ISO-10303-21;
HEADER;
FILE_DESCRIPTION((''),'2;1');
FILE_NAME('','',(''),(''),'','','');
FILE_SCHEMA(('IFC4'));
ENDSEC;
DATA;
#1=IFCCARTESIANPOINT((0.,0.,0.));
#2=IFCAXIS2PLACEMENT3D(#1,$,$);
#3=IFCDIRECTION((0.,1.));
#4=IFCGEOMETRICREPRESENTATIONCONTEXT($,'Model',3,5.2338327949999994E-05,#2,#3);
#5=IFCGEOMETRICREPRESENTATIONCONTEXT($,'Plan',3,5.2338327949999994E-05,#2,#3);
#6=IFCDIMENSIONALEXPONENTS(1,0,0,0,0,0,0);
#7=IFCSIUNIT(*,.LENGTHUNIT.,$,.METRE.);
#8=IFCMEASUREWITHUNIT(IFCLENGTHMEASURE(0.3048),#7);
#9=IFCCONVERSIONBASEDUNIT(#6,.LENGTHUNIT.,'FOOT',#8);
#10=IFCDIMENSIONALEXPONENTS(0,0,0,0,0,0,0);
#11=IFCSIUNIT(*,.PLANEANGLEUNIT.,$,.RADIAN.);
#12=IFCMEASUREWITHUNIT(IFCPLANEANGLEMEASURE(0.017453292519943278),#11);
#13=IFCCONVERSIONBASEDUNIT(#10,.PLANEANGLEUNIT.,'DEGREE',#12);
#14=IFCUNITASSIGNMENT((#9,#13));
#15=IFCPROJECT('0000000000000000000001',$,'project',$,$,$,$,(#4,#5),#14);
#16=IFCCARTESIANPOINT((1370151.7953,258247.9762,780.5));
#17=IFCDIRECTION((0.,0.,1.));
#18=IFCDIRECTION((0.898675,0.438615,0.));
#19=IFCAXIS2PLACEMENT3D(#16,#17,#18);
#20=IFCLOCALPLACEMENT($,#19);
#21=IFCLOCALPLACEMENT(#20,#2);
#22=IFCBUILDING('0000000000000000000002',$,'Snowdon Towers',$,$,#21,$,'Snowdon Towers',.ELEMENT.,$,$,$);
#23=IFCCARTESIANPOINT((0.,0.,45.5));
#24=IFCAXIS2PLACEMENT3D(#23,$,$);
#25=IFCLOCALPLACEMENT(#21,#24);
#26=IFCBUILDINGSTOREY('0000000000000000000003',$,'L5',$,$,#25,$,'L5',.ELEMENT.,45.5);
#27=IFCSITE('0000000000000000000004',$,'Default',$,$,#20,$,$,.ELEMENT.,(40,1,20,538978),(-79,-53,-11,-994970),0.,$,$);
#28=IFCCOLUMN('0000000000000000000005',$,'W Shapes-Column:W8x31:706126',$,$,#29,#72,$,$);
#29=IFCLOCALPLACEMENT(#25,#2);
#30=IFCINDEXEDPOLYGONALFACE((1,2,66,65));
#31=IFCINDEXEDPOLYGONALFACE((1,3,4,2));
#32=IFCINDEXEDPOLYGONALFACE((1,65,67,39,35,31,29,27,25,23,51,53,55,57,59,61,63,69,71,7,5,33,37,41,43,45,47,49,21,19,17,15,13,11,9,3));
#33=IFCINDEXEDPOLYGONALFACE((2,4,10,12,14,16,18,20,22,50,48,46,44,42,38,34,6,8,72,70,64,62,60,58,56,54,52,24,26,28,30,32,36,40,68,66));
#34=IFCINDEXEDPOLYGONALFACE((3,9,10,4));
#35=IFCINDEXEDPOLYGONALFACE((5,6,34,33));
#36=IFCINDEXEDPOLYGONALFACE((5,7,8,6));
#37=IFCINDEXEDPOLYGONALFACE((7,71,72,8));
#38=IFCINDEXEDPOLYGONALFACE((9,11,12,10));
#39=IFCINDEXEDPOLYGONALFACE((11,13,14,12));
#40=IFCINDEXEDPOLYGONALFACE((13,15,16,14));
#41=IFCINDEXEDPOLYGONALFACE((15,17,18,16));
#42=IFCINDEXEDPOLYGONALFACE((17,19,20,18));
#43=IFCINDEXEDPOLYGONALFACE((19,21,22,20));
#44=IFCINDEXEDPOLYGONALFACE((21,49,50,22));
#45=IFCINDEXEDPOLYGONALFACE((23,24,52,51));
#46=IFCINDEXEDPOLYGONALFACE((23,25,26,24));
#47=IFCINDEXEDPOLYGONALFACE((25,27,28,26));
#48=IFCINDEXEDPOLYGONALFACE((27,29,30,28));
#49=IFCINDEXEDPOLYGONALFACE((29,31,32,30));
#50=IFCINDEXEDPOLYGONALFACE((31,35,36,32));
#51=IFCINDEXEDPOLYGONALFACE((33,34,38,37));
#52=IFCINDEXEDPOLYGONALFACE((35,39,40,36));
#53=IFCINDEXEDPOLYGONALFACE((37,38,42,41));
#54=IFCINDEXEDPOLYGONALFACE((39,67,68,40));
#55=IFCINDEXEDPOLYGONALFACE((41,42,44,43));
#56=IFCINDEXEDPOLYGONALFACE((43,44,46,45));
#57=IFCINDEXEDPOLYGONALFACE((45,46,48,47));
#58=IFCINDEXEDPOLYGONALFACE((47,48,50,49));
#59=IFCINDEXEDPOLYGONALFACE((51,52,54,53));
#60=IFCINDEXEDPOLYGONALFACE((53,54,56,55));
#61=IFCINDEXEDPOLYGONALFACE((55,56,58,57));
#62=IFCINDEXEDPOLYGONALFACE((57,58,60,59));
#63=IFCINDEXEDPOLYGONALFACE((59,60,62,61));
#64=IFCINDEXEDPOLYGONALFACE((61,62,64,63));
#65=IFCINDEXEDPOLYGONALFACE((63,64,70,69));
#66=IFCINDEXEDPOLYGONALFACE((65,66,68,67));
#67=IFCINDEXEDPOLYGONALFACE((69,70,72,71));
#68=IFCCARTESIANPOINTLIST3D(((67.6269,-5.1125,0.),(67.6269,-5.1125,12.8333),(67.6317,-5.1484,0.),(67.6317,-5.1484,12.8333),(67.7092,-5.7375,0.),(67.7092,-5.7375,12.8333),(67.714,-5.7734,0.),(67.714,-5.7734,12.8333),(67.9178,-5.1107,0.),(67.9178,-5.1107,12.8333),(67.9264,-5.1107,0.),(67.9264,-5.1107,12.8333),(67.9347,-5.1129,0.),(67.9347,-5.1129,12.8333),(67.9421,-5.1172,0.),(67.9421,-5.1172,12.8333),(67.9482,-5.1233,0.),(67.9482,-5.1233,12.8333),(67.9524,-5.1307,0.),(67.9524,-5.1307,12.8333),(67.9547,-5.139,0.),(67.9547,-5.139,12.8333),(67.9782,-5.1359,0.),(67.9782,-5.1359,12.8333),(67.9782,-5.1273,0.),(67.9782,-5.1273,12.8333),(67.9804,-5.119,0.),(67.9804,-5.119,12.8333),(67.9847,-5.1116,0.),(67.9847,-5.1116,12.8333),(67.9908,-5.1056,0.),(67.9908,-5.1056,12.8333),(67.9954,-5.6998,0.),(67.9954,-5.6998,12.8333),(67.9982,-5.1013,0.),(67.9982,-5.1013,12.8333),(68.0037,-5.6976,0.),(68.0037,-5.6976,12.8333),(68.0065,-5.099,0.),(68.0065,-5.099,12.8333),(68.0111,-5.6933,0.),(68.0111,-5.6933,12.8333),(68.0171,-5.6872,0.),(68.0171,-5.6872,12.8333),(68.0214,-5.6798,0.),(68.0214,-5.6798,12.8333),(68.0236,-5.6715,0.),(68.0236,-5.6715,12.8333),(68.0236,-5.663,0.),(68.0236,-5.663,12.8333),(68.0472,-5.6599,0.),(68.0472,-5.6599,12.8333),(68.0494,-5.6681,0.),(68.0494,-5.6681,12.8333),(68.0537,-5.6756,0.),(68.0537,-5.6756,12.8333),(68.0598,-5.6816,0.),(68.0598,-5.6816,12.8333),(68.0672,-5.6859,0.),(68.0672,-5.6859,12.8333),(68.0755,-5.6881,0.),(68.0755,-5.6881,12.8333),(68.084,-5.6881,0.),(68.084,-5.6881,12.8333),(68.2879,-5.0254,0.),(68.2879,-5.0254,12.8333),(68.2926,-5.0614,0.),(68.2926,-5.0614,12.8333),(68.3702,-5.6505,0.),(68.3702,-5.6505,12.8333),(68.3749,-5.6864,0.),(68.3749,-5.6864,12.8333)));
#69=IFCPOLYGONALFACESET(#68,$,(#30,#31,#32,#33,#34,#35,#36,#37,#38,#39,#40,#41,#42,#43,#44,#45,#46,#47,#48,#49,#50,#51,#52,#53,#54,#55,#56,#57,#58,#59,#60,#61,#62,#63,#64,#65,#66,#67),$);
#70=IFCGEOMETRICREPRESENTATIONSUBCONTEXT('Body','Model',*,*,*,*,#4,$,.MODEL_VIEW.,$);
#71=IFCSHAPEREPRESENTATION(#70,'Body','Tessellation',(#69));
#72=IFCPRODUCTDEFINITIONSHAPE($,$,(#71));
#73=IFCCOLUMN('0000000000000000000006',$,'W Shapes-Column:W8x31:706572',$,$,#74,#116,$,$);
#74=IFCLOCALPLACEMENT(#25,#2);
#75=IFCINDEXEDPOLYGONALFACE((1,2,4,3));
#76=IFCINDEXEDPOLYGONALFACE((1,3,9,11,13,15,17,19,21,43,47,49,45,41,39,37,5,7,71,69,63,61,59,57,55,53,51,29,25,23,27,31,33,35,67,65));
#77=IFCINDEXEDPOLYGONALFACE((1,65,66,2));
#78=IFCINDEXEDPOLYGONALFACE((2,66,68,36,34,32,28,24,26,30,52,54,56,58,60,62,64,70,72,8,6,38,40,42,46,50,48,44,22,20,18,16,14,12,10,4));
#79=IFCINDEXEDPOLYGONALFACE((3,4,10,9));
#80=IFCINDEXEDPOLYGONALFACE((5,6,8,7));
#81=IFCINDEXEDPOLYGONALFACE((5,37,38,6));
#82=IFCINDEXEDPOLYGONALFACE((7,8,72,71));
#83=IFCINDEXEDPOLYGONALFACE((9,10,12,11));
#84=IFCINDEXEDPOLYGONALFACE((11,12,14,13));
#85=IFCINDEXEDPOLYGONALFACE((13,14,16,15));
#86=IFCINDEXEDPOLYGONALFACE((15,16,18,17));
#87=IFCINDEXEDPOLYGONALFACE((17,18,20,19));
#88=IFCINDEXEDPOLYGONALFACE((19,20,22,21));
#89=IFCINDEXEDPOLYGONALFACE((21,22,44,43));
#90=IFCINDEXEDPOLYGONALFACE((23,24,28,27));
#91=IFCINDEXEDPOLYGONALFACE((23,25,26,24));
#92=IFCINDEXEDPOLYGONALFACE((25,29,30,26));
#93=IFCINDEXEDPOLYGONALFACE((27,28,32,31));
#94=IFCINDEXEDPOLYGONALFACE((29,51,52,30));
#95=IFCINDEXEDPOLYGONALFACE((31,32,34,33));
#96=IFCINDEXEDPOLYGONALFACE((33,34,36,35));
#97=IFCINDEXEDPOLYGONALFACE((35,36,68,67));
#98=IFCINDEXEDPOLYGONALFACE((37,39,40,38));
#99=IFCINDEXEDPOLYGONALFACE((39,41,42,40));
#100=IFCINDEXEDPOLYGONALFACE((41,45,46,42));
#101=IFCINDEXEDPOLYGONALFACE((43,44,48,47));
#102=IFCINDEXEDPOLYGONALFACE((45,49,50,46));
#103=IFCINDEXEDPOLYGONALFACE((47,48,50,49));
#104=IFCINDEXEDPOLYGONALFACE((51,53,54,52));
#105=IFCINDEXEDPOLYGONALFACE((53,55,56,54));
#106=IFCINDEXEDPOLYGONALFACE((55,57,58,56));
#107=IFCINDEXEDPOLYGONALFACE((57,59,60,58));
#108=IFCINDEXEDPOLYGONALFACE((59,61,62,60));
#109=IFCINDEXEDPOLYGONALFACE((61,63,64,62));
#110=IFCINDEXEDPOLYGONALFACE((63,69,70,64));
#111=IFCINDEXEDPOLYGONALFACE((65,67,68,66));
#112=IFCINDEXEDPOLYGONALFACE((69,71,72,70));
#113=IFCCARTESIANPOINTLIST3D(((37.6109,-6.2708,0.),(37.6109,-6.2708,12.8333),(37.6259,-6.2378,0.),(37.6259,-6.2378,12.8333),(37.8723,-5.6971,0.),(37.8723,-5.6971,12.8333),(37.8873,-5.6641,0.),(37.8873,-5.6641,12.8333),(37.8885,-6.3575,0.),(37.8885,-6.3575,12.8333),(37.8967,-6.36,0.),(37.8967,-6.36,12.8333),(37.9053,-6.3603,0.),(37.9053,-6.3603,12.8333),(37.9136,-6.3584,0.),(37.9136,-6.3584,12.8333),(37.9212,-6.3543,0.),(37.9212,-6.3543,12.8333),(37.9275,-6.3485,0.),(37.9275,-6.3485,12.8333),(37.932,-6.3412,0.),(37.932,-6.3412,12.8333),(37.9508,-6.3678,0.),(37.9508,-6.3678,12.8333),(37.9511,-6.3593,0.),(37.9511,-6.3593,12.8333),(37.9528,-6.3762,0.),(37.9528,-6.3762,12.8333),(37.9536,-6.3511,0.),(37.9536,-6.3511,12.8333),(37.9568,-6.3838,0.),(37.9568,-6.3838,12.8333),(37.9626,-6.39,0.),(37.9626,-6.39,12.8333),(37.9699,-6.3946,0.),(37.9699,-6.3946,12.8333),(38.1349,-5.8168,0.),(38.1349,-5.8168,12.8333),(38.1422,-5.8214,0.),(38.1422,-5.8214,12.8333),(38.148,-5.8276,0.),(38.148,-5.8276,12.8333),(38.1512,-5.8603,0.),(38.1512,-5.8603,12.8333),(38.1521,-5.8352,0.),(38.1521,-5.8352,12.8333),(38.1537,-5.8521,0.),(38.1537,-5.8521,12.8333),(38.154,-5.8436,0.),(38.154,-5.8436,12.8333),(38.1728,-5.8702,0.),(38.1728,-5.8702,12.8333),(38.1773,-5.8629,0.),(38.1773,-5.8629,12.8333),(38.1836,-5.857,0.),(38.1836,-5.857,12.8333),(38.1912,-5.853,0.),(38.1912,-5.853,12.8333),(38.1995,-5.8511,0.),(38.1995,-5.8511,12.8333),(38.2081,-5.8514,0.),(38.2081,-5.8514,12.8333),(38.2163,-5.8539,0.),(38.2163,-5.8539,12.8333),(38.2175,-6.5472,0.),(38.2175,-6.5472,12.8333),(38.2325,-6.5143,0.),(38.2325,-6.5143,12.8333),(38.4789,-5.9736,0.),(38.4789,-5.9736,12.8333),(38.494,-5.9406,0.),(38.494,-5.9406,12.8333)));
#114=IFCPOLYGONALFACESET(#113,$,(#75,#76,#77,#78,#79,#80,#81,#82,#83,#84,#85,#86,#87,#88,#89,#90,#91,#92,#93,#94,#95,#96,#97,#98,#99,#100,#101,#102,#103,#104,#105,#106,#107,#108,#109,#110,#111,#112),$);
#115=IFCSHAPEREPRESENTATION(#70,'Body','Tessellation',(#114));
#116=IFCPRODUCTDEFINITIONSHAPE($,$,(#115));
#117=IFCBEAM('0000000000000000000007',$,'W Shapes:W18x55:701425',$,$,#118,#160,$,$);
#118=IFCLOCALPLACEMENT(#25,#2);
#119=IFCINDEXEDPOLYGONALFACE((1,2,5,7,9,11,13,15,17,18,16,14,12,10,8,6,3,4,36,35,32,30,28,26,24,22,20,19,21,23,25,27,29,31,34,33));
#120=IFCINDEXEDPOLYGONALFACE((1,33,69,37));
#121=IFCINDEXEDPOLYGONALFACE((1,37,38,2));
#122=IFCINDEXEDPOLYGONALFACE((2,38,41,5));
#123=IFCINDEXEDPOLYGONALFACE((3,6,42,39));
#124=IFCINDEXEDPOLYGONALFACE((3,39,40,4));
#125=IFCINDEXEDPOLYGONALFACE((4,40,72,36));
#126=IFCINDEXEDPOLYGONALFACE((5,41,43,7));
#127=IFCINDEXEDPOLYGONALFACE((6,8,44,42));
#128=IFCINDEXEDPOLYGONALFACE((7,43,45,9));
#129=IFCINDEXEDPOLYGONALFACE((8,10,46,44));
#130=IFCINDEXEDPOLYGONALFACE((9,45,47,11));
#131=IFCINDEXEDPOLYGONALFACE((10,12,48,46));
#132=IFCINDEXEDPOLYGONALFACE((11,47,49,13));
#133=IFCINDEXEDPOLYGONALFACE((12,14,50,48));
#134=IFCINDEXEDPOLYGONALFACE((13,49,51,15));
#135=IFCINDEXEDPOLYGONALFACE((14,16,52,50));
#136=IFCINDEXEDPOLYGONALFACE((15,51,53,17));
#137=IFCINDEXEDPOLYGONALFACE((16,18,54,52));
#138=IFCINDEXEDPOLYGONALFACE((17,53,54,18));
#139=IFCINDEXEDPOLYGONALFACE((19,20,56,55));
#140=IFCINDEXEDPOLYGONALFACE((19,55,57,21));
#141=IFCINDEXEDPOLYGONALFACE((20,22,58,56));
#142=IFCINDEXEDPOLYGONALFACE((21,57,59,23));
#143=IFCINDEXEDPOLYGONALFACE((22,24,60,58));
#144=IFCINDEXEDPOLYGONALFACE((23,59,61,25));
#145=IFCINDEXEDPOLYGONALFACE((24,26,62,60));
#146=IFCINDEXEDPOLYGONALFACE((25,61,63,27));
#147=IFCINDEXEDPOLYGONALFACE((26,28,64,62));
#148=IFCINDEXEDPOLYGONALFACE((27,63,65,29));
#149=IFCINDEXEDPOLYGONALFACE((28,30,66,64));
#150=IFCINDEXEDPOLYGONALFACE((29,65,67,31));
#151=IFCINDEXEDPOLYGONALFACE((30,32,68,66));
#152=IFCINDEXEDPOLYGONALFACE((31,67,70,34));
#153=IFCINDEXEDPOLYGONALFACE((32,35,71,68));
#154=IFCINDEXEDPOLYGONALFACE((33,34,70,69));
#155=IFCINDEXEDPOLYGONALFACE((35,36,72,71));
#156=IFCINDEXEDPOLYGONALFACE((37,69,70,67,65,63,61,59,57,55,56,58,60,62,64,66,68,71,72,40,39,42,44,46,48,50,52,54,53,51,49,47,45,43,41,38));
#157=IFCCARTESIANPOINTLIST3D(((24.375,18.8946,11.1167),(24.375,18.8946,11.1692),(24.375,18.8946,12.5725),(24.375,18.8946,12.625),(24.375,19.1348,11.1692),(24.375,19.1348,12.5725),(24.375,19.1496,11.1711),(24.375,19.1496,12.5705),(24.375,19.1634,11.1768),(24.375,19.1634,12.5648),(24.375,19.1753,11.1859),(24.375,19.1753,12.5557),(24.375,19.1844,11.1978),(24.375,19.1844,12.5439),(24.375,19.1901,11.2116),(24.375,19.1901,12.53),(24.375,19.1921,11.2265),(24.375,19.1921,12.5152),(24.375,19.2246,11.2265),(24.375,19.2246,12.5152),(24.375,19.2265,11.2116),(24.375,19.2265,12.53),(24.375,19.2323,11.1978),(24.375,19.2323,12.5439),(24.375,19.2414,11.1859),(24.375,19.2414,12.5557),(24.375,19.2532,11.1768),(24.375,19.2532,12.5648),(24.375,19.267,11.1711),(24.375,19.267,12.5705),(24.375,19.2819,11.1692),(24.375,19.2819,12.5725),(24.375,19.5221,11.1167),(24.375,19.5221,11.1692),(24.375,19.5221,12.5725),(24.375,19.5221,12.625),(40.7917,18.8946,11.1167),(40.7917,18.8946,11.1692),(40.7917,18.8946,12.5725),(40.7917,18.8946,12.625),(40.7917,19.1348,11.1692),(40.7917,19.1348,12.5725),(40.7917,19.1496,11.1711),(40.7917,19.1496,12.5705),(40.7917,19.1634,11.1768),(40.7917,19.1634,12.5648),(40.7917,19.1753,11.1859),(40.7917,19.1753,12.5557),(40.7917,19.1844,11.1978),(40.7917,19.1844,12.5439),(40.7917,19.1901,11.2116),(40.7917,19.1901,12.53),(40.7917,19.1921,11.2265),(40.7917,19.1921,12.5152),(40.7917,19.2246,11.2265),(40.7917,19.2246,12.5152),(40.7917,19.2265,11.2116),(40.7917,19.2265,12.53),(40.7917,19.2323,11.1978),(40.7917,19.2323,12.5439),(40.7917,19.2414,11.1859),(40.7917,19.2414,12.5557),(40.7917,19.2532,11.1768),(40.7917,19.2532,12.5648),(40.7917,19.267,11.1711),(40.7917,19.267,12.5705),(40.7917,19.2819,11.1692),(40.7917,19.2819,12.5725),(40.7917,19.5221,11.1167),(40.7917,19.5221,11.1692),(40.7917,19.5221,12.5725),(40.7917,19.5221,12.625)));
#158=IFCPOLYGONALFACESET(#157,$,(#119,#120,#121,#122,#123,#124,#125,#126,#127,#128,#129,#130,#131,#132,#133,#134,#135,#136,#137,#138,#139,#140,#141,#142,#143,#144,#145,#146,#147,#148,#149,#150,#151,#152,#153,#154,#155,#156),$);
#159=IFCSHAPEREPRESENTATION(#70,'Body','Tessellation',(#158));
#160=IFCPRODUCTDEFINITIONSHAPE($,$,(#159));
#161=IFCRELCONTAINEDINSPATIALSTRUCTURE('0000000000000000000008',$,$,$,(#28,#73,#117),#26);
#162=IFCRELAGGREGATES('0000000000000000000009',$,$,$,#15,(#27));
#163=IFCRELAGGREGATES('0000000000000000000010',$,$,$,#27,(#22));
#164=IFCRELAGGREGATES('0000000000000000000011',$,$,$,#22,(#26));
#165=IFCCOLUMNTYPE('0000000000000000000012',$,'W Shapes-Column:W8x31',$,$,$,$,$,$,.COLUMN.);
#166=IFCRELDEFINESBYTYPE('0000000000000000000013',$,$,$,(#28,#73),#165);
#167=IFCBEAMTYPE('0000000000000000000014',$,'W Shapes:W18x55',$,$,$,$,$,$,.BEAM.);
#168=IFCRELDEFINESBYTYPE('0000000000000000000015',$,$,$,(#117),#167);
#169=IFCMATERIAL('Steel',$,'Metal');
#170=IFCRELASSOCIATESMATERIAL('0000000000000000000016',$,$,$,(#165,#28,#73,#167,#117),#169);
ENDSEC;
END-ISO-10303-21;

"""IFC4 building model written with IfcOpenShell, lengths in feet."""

from ifc_helpers import new_model, entity, si_unit, converted_unit, direction, frame, origin, place, context, subcontext, project, spatial, line, arc, indexed_curve, outline, extrude, source, transform, mapped, material, type_object, type_shapes, element, save


model = new_model("IFC4")

# Units and contexts
model_context = context("Model", 3, precision=5.2338327949999994e-05, world=origin(), true_north=direction((0.0, 1.0)))
plan_context = context("Plan", 3, precision=5.2338327949999994e-05, world=origin(), true_north=direction((0.0, 1.0)))
body_context = subcontext(model_context, "Body", "Model", "MODEL_VIEW")
ifc_project = project(units=[converted_unit("LENGTHUNIT", "FOOT", entity("IfcLengthMeasure", 0.3048), si_unit("LENGTHUNIT", "METRE"), dimensions=[1, 0, 0, 0, 0, 0, 0]), converted_unit("PLANEANGLEUNIT", "DEGREE", entity("IfcPlaneAngleMeasure", 0.017453292519943278), si_unit("PLANEANGLEUNIT", "RADIAN"), dimensions=[0, 0, 0, 0, 0, 0, 0])], contexts=[model_context, plan_context])

# Site, building, storey
site_placement = place(None, frame((1370151.7953, 258247.9762, 780.5), z_axis=(0.0, 0.0, 1.0), x_axis=(0.898675, 0.438615, 0.0)))
site = spatial("IfcSite", under=ifc_project, at=site_placement, Name="Default", CompositionType="ELEMENT", RefLatitude=(40, 1, 20, 538978), RefLongitude=(-79, -53, -11, -994970), RefElevation=0.0)
building_placement = place(site_placement, origin())
building = spatial("IfcBuilding", under=site, at=building_placement, Name="Snowdon Towers", LongName="Snowdon Towers", CompositionType="ELEMENT")
storey_placement = place(building_placement, frame((0.0, 0.0, 45.5)))
storey = spatial("IfcBuildingStorey", under=building, at=storey_placement, Name="L5", LongName="L5", CompositionType="ELEMENT", Elevation=45.5)

# Columns
ifc_material = material(Name="Steel", Category="Metal")
column_type = type_object("IfcColumnType", Name="W Shapes-Column:W8x31", PredefinedType="COLUMN", material=ifc_material)
shared_shape_1 = source(origin(), body_context, "Body", "SweptSolid", [
    extrude(outline(indexed_curve([(-0.3333, -0.3333), (0.3333, -0.3333), (0.3333, -0.2971), (0.0447, -0.2971), (0.0215, -0.2875), (0.0119, -0.2642), (0.0119, 0.2642), (0.0215, 0.2875), (0.0447, 0.2971), (0.3333, 0.2971), (0.3333, 0.3333), (-0.3333, 0.3333), (-0.3333, 0.2971), (-0.0447, 0.2971), (-0.0215, 0.2875), (-0.0119, 0.2643), (-0.0119, -0.2642), (-0.0215, -0.2875), (-0.0447, -0.2971), (-0.3333, -0.2971)], segments=[line(1, 2, 3, 4), arc(4, 5, 6), line(6, 7), arc(7, 8, 9), line(9, 10, 11, 12, 13, 14), arc(14, 15, 16), line(16, 17), arc(17, 18, 19), line(19, 20, 1)], self_intersect=False)), frame((0.0, 0.0, 45.5), z_axis=(0.0, 0.0, 1.0), x_axis=(-1.0, 0.0, 0.0)), (0.0, 0.0, 1.0), 12.8333),
])
type_shapes(column_type, [shared_shape_1])
for number, where, z_axis, x_axis, name in (
    (1, (68.0009, -5.3994, -45.5), (0.0, 0.0, 1.0), (0.991445, 0.130526, 0.0), "W Shapes-Column:W8x31:706126"),
    (2, (38.0524, -6.1057, -45.5), (0.0, 0.0, 1.0), (0.909961, -0.414693, 0.0), "W Shapes-Column:W8x31:706572"),
):
    element("IfcColumn", number, at=place(storey_placement, frame(where, z_axis=z_axis, x_axis=x_axis)), inside=storey, type_object=column_type, material=ifc_material, Name=name, context=body_context, shape_type="MappedRepresentation", body=[
        mapped(shared_shape_1, transform((0.0, 0.0, 0.0), scale=1.0)),
    ])

# Beam
beam_type_1 = type_object("IfcBeamType", Name="W Shapes:W18x55", PredefinedType="BEAM", material=ifc_material)
shared_shape_2 = source(origin(), body_context, "Body", "SweptSolid", [
    extrude(outline(indexed_curve([(-0.7542, -0.3138), (-0.7017, -0.3138), (-0.7017, -0.0735), (-0.6849, -0.033), (-0.6444, -0.0162), (0.6444, -0.0162), (0.6849, -0.033), (0.7017, -0.0735), (0.7017, -0.3138), (0.7542, -0.3138), (0.7542, 0.3138), (0.7017, 0.3138), (0.7017, 0.0735), (0.6849, 0.033), (0.6444, 0.0163), (-0.6444, 0.0163), (-0.6849, 0.033), (-0.7017, 0.0735), (-0.7017, 0.3137), (-0.7542, 0.3137)], segments=[line(1, 2, 3), arc(3, 4, 5), line(5, 6), arc(6, 7, 8), line(8, 9, 10, 11, 12, 13), arc(13, 14, 15), line(15, 16), arc(16, 17, 18), line(18, 19, 20, 1)], self_intersect=False)), frame((-8.2083, 0.0, 0.0), z_axis=(1.0, 0.0, 0.0), x_axis=(0.0, 0.0, -1.0)), (0.0, 0.0, 1.0), 16.4167),
])
type_shapes(beam_type_1, [shared_shape_2])
beam_1_placement = place(storey_placement, frame((32.5833, 19.2083, 11.8708)))
element("IfcBeam", 3, at=beam_1_placement, inside=storey, type_object=beam_type_1, material=ifc_material, Name="W Shapes:W18x55:701425", context=body_context, shape_type="MappedRepresentation", body=[
    mapped(shared_shape_2, transform((0.0, 0.0, 0.0), scale=1.0)),
])

save(model, "model.ifc")
